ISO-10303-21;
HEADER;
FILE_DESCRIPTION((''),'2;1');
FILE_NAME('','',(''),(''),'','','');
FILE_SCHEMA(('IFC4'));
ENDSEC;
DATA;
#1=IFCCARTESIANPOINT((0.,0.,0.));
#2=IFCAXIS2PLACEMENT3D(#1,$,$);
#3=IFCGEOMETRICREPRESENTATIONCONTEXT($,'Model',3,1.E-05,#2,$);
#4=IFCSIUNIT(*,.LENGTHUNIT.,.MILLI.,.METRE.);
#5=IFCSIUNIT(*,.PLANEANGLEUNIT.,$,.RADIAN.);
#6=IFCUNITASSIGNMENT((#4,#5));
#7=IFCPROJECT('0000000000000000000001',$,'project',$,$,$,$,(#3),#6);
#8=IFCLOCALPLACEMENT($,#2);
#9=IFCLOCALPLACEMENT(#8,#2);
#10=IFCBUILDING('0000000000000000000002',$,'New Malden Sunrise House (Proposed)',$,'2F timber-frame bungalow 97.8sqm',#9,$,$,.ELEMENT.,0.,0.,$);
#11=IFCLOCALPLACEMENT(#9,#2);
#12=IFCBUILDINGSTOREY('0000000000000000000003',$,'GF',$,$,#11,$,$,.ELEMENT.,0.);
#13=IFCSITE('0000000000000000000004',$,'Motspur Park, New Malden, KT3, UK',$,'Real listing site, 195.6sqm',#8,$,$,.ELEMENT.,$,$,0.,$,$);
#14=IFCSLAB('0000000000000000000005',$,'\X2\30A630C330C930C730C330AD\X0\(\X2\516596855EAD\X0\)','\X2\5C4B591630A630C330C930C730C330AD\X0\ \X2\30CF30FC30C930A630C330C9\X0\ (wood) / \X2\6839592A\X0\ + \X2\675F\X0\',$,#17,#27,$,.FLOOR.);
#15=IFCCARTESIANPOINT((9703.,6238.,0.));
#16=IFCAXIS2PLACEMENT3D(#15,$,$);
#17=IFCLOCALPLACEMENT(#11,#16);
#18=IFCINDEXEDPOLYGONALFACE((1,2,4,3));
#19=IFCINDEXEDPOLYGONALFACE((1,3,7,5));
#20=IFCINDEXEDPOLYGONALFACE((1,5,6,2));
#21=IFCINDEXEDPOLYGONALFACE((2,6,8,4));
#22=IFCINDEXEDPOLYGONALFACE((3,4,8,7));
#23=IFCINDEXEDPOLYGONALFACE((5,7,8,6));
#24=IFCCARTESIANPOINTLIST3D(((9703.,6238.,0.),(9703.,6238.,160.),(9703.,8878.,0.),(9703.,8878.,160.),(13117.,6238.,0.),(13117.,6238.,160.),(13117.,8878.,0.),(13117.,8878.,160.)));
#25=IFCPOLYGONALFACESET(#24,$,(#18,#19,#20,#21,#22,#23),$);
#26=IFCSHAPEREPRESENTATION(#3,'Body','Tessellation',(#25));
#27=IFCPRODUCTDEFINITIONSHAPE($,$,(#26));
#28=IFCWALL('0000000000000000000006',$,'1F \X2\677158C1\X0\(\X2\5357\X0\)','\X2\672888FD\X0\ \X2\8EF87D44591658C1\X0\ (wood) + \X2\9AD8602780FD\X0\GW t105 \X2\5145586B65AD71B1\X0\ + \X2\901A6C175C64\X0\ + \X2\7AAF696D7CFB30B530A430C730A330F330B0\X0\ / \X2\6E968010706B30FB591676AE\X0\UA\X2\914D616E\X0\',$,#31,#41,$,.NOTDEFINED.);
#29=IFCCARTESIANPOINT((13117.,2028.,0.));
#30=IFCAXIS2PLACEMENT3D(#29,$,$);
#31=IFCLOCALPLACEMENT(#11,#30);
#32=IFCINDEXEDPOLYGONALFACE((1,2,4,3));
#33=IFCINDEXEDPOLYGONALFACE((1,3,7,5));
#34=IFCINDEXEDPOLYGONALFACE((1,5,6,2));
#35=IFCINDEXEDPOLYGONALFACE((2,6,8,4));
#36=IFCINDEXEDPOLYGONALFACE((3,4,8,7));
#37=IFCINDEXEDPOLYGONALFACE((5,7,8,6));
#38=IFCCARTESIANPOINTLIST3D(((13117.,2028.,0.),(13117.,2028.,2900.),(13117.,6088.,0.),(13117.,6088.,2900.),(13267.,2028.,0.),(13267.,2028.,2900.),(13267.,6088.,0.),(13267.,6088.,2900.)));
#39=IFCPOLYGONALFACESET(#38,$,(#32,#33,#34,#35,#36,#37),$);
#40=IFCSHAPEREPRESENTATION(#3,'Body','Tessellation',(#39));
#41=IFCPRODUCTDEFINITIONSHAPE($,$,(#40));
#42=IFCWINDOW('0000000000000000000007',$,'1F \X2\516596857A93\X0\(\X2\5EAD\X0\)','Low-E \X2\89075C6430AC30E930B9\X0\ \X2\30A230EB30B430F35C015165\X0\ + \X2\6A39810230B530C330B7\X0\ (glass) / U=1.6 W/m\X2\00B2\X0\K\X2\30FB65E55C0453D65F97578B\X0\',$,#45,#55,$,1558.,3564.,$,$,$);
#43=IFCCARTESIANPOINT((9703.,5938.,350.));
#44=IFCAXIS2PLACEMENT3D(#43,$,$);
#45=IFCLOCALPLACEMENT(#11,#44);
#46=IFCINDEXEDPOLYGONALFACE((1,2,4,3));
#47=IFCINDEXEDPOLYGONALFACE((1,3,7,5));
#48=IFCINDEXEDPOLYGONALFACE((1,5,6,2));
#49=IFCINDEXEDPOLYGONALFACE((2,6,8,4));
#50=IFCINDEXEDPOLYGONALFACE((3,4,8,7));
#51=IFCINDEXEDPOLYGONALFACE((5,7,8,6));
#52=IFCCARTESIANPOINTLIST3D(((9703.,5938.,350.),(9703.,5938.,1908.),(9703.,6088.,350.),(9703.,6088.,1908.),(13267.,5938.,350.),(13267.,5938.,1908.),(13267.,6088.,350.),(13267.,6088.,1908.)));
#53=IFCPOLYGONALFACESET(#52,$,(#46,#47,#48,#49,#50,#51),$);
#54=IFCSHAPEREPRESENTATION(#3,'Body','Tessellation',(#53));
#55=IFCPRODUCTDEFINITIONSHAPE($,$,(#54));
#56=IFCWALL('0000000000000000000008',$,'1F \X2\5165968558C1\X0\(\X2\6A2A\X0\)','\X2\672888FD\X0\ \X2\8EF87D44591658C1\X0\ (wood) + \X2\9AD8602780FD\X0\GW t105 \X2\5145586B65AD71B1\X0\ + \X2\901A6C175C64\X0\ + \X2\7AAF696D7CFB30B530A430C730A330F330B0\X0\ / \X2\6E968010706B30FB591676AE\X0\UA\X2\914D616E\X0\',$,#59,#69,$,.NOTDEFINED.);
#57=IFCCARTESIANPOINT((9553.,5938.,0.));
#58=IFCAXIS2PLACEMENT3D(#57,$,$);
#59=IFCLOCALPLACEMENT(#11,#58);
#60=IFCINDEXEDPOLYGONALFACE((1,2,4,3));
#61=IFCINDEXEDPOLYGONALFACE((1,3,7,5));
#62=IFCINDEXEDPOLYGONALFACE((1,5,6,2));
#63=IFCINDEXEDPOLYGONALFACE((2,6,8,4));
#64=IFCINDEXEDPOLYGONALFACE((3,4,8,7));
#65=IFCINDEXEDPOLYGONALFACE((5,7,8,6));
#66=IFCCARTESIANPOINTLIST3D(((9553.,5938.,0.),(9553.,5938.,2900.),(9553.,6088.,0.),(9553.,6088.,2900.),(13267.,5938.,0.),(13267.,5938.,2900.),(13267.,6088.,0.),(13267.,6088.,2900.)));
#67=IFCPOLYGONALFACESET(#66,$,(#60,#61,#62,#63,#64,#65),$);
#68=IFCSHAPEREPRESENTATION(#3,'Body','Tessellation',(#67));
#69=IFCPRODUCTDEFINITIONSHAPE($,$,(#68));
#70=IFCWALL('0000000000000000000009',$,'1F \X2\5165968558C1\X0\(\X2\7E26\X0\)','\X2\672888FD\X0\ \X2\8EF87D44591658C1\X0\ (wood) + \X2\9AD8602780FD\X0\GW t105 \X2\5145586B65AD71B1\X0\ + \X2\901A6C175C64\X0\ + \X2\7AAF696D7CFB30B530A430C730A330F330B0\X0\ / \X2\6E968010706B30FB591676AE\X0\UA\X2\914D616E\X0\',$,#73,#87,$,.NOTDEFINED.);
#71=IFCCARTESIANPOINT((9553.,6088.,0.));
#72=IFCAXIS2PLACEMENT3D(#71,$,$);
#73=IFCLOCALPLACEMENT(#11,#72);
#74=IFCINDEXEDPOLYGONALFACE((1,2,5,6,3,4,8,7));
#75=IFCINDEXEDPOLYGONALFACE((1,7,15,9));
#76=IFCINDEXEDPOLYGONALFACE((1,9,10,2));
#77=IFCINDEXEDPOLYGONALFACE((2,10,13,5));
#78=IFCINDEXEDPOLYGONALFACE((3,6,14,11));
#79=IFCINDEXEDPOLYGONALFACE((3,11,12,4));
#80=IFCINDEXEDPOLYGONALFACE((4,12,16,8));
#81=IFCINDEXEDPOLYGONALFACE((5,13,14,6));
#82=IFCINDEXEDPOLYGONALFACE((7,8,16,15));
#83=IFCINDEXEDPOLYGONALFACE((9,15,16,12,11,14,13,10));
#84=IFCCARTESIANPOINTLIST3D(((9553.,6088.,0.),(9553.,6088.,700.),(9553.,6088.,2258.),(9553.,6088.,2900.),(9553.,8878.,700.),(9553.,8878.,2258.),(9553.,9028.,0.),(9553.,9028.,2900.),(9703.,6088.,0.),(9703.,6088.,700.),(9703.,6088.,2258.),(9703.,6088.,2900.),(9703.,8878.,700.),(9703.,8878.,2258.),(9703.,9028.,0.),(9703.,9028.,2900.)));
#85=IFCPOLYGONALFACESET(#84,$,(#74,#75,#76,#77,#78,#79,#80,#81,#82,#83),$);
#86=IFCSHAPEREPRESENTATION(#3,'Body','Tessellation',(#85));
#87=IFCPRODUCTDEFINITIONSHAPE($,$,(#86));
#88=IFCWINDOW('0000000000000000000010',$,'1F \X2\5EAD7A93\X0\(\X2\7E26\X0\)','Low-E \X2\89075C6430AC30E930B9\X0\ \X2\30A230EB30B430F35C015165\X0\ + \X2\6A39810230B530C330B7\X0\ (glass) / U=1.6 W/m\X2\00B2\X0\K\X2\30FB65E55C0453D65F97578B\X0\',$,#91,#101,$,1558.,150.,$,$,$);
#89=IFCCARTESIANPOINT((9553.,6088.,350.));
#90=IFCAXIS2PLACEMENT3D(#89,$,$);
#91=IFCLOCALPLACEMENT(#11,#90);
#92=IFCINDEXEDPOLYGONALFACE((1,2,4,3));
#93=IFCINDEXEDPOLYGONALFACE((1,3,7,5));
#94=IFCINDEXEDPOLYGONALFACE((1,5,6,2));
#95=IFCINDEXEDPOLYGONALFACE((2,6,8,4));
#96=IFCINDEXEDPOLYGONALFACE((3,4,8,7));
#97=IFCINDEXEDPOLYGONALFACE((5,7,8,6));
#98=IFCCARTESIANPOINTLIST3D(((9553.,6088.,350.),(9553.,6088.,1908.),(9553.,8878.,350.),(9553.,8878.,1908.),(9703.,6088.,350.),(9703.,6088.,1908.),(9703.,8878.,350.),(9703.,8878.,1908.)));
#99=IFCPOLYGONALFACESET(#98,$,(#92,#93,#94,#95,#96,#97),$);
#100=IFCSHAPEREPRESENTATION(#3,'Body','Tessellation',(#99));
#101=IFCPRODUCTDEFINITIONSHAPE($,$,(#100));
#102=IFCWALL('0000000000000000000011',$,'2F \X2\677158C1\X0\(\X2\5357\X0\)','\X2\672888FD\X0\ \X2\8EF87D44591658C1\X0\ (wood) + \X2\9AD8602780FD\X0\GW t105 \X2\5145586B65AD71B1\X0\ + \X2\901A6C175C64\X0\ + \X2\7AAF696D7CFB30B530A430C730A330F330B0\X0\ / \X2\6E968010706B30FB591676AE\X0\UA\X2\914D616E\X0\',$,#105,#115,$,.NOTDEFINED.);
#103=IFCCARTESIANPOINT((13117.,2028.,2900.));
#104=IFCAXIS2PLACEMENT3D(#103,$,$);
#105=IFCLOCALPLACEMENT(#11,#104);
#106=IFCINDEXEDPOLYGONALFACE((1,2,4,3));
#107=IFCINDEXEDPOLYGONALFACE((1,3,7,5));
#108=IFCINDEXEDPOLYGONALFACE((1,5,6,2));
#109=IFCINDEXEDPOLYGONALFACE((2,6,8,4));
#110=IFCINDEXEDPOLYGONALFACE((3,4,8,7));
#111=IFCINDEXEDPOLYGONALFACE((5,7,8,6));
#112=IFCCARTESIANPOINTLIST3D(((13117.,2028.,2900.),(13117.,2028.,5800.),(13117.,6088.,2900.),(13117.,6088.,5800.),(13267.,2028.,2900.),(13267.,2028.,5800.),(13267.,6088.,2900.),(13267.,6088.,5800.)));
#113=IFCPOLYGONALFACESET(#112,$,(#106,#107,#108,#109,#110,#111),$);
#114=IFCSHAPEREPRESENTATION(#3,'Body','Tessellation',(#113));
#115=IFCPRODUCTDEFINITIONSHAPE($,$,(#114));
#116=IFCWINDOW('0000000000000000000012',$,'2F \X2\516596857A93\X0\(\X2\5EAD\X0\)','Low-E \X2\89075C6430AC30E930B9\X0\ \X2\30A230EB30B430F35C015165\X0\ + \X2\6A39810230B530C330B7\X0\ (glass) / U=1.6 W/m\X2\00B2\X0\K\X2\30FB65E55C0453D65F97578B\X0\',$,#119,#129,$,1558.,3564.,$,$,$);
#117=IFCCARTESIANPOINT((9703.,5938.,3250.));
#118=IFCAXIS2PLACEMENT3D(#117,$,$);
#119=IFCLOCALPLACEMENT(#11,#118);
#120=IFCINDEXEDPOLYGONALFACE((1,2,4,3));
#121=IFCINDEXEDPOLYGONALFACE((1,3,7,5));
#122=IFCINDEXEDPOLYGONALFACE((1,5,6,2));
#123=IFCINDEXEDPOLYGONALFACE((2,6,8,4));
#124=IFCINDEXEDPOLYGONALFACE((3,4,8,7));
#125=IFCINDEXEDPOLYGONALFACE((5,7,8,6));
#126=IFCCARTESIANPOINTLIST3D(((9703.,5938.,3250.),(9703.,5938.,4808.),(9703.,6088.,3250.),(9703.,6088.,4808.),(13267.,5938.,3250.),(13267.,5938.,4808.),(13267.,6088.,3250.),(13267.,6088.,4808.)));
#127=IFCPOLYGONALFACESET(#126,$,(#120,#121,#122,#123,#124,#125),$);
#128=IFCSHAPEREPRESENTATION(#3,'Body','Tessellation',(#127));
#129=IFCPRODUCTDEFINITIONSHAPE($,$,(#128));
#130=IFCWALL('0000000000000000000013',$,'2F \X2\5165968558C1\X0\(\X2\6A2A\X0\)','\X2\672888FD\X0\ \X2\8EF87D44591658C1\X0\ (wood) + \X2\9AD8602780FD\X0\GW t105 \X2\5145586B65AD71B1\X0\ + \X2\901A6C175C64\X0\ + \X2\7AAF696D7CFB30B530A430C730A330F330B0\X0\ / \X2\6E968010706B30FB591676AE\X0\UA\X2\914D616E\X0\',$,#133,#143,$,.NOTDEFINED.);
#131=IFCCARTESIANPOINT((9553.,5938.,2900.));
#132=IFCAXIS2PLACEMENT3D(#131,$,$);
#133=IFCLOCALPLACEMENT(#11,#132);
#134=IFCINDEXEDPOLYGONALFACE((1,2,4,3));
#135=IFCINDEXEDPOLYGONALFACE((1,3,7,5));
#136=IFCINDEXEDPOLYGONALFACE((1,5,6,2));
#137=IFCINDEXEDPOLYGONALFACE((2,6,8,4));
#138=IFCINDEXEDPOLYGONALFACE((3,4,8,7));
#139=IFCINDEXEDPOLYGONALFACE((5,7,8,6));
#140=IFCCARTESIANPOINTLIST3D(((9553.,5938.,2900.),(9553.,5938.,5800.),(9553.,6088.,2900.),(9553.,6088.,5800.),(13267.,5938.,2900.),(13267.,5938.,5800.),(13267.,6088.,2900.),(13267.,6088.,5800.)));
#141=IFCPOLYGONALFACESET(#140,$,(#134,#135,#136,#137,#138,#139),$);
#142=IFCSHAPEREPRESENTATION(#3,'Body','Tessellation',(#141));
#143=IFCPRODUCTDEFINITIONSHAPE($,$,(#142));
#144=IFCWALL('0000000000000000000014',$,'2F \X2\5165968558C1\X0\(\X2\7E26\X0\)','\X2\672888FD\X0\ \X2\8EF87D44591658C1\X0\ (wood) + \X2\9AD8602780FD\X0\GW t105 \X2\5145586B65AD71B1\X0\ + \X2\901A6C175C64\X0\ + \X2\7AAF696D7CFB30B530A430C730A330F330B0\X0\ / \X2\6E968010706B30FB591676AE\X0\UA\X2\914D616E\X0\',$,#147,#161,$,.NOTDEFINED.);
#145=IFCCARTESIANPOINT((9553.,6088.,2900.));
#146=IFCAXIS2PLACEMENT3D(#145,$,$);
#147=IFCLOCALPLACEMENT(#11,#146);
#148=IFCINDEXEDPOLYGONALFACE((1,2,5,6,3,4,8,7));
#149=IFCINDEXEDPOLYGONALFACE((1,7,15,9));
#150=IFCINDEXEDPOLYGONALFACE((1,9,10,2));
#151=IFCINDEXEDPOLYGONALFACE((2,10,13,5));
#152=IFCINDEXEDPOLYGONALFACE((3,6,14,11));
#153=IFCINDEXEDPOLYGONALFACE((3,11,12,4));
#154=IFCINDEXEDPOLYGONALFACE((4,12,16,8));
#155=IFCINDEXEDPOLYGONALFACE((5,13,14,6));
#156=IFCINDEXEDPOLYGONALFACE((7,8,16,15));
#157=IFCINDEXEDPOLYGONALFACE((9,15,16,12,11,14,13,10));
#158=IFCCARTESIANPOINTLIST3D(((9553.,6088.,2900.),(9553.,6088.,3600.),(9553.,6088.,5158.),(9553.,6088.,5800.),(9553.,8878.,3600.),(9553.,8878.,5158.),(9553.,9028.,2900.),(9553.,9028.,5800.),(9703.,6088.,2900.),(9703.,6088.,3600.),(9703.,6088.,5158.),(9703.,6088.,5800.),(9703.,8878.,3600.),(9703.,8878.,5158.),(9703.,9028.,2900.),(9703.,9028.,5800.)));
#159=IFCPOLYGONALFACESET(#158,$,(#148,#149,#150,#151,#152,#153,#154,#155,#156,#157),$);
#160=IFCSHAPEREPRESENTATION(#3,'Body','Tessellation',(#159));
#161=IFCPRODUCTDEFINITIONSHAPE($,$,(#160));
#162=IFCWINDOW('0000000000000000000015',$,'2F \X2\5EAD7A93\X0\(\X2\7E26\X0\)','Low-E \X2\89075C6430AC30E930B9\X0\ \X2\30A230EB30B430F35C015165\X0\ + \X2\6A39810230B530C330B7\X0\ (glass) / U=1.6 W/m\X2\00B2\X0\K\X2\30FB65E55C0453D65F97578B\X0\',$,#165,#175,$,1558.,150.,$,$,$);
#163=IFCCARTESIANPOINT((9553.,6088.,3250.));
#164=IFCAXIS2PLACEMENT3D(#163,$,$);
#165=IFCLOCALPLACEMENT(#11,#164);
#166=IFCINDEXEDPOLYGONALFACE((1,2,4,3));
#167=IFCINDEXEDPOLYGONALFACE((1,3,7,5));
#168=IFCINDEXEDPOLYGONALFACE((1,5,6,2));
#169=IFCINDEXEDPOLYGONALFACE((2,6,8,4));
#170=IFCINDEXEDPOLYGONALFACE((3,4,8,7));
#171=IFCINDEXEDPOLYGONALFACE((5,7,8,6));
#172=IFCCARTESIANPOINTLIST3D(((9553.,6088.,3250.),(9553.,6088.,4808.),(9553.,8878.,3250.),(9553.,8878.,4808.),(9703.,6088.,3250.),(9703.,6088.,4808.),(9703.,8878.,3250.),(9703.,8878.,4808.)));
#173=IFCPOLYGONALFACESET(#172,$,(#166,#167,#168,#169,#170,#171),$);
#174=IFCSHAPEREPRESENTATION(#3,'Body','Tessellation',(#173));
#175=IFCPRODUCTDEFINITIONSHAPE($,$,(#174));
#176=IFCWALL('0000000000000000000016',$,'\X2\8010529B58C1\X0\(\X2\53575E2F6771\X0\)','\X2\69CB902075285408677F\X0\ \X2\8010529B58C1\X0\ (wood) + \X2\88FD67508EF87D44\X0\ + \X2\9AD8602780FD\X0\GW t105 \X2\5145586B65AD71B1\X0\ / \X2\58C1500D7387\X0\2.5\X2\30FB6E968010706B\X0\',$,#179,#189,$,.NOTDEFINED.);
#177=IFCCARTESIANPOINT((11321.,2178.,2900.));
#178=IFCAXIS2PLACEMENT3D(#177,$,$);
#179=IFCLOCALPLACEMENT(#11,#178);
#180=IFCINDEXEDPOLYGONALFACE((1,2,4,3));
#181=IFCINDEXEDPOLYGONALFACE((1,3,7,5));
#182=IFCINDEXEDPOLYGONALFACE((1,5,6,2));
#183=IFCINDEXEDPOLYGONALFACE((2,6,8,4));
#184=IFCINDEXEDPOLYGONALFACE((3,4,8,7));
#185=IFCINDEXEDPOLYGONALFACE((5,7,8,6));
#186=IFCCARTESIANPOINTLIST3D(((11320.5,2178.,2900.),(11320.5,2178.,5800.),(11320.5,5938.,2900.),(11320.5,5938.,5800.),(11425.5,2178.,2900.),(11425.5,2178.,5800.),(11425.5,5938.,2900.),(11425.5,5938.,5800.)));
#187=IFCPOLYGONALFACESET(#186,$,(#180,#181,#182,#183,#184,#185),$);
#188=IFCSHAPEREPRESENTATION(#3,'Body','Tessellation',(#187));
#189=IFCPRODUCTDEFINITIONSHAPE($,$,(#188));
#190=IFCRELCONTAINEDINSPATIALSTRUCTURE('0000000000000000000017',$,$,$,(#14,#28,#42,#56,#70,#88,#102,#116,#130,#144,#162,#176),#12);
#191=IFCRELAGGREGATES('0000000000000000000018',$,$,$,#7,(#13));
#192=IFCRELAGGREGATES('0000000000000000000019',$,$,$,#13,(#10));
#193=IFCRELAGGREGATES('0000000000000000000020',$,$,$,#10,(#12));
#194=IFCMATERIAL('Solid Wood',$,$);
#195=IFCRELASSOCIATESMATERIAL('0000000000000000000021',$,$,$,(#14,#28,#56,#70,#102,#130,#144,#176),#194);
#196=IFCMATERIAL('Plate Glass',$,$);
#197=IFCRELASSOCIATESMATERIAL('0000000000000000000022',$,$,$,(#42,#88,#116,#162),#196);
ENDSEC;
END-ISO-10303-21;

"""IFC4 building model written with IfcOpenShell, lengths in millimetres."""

from ifc_helpers import new_model, si_unit, frame, frame_2d, origin, place, context, project, spatial, rectangle, extrude, material, element, fill, save


model = new_model("IFC4")

# Units and contexts
model_context = context("Model", 3, precision=1e-05, world=origin())
ifc_project = project(units=[si_unit("LENGTHUNIT", "METRE", prefix="MILLI"), si_unit("PLANEANGLEUNIT", "RADIAN")], contexts=[model_context])

# Site, building, storey
site_placement = place(None, origin())
site = spatial("IfcSite", under=ifc_project, at=site_placement, Name="Motspur Park, New Malden, KT3, UK", ObjectType="Real listing site, 195.6sqm", CompositionType="ELEMENT", RefElevation=0.0)
building_placement = place(site_placement, origin())
building = spatial("IfcBuilding", under=site, at=building_placement, Name="New Malden Sunrise House (Proposed)", ObjectType="2F timber-frame bungalow 97.8sqm", CompositionType="ELEMENT", ElevationOfRefHeight=0.0, ElevationOfTerrain=0.0)
storey_placement = place(building_placement, origin())
storey = spatial("IfcBuildingStorey", under=building, at=storey_placement, Name="GF", CompositionType="ELEMENT", Elevation=0.0)

# Slab
ifc_material_1 = material(Name="Solid Wood")
slab_placement = place(storey_placement, frame((9703.0, 6238.0, 0.0)))
element("IfcSlab", 1, at=slab_placement, inside=storey, material=ifc_material_1, Name="ウッドデッキ(入隅庭)", Description="屋外ウッドデッキ ハードウッド (wood) / 根太 + 束", PredefinedType="FLOOR", context=model_context, shape_type="SweptSolid", body=[
    extrude(rectangle(XDim=3414.0, YDim=2640.0, at=frame_2d((1707.0, 1320.0))), frame((9703.0, 6238.0, 0.0)), (0.0, 0.0, 1.0), 160.0),
])

# Wall, opening, window
wall_1_placement = place(storey_placement, frame((13117.0, 2028.0, 0.0)))
wall_1 = element("IfcWall", 2, at=wall_1_placement, inside=storey, material=ifc_material_1, Name="1F 東壁(南)", Description="木製 軸組外壁 (wood) + 高性能GW t105 充填断熱 + 通気層 + 窯業系サイディング / 準耐火・外皮UA配慮", PredefinedType="NOTDEFINED", context=model_context, shape_type="SweptSolid", body=[
    extrude(rectangle(XDim=150.0, YDim=4060.0, at=frame_2d((75.0, 2030.0))), frame((13117.0, 2028.0, 0.0)), (0.0, 0.0, 1.0), 2900.0),
])
opening_1_placement = place(storey_placement, frame((9703.0, 5938.0, 350.0)))
opening_1 = element("IfcOpeningElement", 3, at=opening_1_placement, cuts=wall_1, PredefinedType="NOTDEFINED", context=model_context, shape_type="SweptSolid", body=[
    extrude(rectangle(XDim=3564.0, YDim=150.0, at=frame_2d((1782.0, 75.0))), frame((9703.0, 5938.0, 350.0)), (0.0, 0.0, 1.0), 1558.0),
])
ifc_material_2 = material(Name="Plate Glass")
window_1_placement = place(storey_placement, frame((9703.0, 5938.0, 350.0)))
window_1 = element("IfcWindow", 4, at=window_1_placement, inside=storey, material=ifc_material_2, Name="1F 入隅窓(庭)", Description="Low-E 複層ガラス アルゴン封入 + 樹脂サッシ (glass) / U=1.6 W/m²K・日射取得型", OverallHeight=1558.0, OverallWidth=3564.0, context=model_context, shape_type="SweptSolid", body=[
    extrude(rectangle(XDim=3564.0, YDim=150.0, at=frame_2d((1782.0, 75.0))), frame((9703.0, 5938.0, 350.0)), (0.0, 0.0, 1.0), 1558.0),
])
fill(opening_1, window_1)

# Wall
wall_2_placement = place(storey_placement, frame((9553.0, 5938.0, 0.0)))
element("IfcWall", 5, at=wall_2_placement, inside=storey, material=ifc_material_1, Name="1F 入隅壁(横)", Description="木製 軸組外壁 (wood) + 高性能GW t105 充填断熱 + 通気層 + 窯業系サイディング / 準耐火・外皮UA配慮", PredefinedType="NOTDEFINED", context=model_context, shape_type="SweptSolid", body=[
    extrude(rectangle(XDim=3714.0, YDim=150.0, at=frame_2d((1857.0, 75.0))), frame((9553.0, 5938.0, 0.0)), (0.0, 0.0, 1.0), 2900.0),
])

# Wall, opening, window
wall_3_placement = place(storey_placement, frame((9553.0, 6088.0, 0.0)))
wall_3 = element("IfcWall", 6, at=wall_3_placement, inside=storey, material=ifc_material_1, Name="1F 入隅壁(縦)", Description="木製 軸組外壁 (wood) + 高性能GW t105 充填断熱 + 通気層 + 窯業系サイディング / 準耐火・外皮UA配慮", PredefinedType="NOTDEFINED", context=model_context, shape_type="SweptSolid", body=[
    extrude(rectangle(XDim=150.0, YDim=2940.0, at=frame_2d((75.0, 1470.0))), frame((9553.0, 6088.0, 0.0)), (0.0, 0.0, 1.0), 2900.0),
])
opening_2_placement = place(storey_placement, frame((9553.0, 6088.0, 350.0)))
opening_2 = element("IfcOpeningElement", 7, at=opening_2_placement, cuts=wall_3, PredefinedType="NOTDEFINED", context=model_context, shape_type="SweptSolid", body=[
    extrude(rectangle(XDim=150.0, YDim=2790.0, at=frame_2d((75.0, 1395.0))), frame((9553.0, 6088.0, 350.0)), (0.0, 0.0, 1.0), 1558.0),
])
window_2_placement = place(storey_placement, frame((9553.0, 6088.0, 350.0)))
window_2 = element("IfcWindow", 8, at=window_2_placement, inside=storey, material=ifc_material_2, Name="1F 庭窓(縦)", Description="Low-E 複層ガラス アルゴン封入 + 樹脂サッシ (glass) / U=1.6 W/m²K・日射取得型", OverallHeight=1558.0, OverallWidth=150.0, context=model_context, shape_type="SweptSolid", body=[
    extrude(rectangle(XDim=150.0, YDim=2790.0, at=frame_2d((75.0, 1395.0))), frame((9553.0, 6088.0, 350.0)), (0.0, 0.0, 1.0), 1558.0),
])
fill(opening_2, window_2)

# Wall, opening, window
wall_4_placement = place(storey_placement, frame((13117.0, 2028.0, 2900.0)))
wall_4 = element("IfcWall", 9, at=wall_4_placement, inside=storey, material=ifc_material_1, Name="2F 東壁(南)", Description="木製 軸組外壁 (wood) + 高性能GW t105 充填断熱 + 通気層 + 窯業系サイディング / 準耐火・外皮UA配慮", PredefinedType="NOTDEFINED", context=model_context, shape_type="SweptSolid", body=[
    extrude(rectangle(XDim=150.0, YDim=4060.0, at=frame_2d((75.0, 2030.0))), frame((13117.0, 2028.0, 2900.0)), (0.0, 0.0, 1.0), 2900.0),
])
opening_3_placement = place(storey_placement, frame((9703.0, 5938.0, 3250.0)))
opening_3 = element("IfcOpeningElement", 10, at=opening_3_placement, cuts=wall_4, PredefinedType="NOTDEFINED", context=model_context, shape_type="SweptSolid", body=[
    extrude(rectangle(XDim=3564.0, YDim=150.0, at=frame_2d((1782.0, 75.0))), frame((9703.0, 5938.0, 3250.0)), (0.0, 0.0, 1.0), 1558.0),
])
window_3_placement = place(storey_placement, frame((9703.0, 5938.0, 3250.0)))
window_3 = element("IfcWindow", 11, at=window_3_placement, inside=storey, material=ifc_material_2, Name="2F 入隅窓(庭)", Description="Low-E 複層ガラス アルゴン封入 + 樹脂サッシ (glass) / U=1.6 W/m²K・日射取得型", OverallHeight=1558.0, OverallWidth=3564.0, context=model_context, shape_type="SweptSolid", body=[
    extrude(rectangle(XDim=3564.0, YDim=150.0, at=frame_2d((1782.0, 75.0))), frame((9703.0, 5938.0, 3250.0)), (0.0, 0.0, 1.0), 1558.0),
])
fill(opening_3, window_3)

# Wall
wall_5_placement = place(storey_placement, frame((9553.0, 5938.0, 2900.0)))
element("IfcWall", 12, at=wall_5_placement, inside=storey, material=ifc_material_1, Name="2F 入隅壁(横)", Description="木製 軸組外壁 (wood) + 高性能GW t105 充填断熱 + 通気層 + 窯業系サイディング / 準耐火・外皮UA配慮", PredefinedType="NOTDEFINED", context=model_context, shape_type="SweptSolid", body=[
    extrude(rectangle(XDim=3714.0, YDim=150.0, at=frame_2d((1857.0, 75.0))), frame((9553.0, 5938.0, 2900.0)), (0.0, 0.0, 1.0), 2900.0),
])

# Wall, opening, window
wall_6_placement = place(storey_placement, frame((9553.0, 6088.0, 2900.0)))
wall_6 = element("IfcWall", 13, at=wall_6_placement, inside=storey, material=ifc_material_1, Name="2F 入隅壁(縦)", Description="木製 軸組外壁 (wood) + 高性能GW t105 充填断熱 + 通気層 + 窯業系サイディング / 準耐火・外皮UA配慮", PredefinedType="NOTDEFINED", context=model_context, shape_type="SweptSolid", body=[
    extrude(rectangle(XDim=150.0, YDim=2940.0, at=frame_2d((75.0, 1470.0))), frame((9553.0, 6088.0, 2900.0)), (0.0, 0.0, 1.0), 2900.0),
])
opening_4_placement = place(storey_placement, frame((9553.0, 6088.0, 3250.0)))
opening_4 = element("IfcOpeningElement", 14, at=opening_4_placement, cuts=wall_6, PredefinedType="NOTDEFINED", context=model_context, shape_type="SweptSolid", body=[
    extrude(rectangle(XDim=150.0, YDim=2790.0, at=frame_2d((75.0, 1395.0))), frame((9553.0, 6088.0, 3250.0)), (0.0, 0.0, 1.0), 1558.0),
])
window_4_placement = place(storey_placement, frame((9553.0, 6088.0, 3250.0)))
window_4 = element("IfcWindow", 15, at=window_4_placement, inside=storey, material=ifc_material_2, Name="2F 庭窓(縦)", Description="Low-E 複層ガラス アルゴン封入 + 樹脂サッシ (glass) / U=1.6 W/m²K・日射取得型", OverallHeight=1558.0, OverallWidth=150.0, context=model_context, shape_type="SweptSolid", body=[
    extrude(rectangle(XDim=150.0, YDim=2790.0, at=frame_2d((75.0, 1395.0))), frame((9553.0, 6088.0, 3250.0)), (0.0, 0.0, 1.0), 1558.0),
])
fill(opening_4, window_4)

# Wall
wall_7_placement = place(storey_placement, frame((11321.0, 2178.0, 2900.0)))
element("IfcWall", 16, at=wall_7_placement, inside=storey, material=ifc_material_1, Name="耐力壁(南帯東)", Description="構造用合板 耐力壁 (wood) + 製材軸組 + 高性能GW t105 充填断熱 / 壁倍率2.5・準耐火", PredefinedType="NOTDEFINED", context=model_context, shape_type="SweptSolid", body=[
    extrude(rectangle(XDim=105.0, YDim=3760.0, at=frame_2d((52.0, 1880.0))), frame((11321.0, 2178.0, 2900.0)), (0.0, 0.0, 1.0), 2900.0),
])

save(model, "model.ifc")
